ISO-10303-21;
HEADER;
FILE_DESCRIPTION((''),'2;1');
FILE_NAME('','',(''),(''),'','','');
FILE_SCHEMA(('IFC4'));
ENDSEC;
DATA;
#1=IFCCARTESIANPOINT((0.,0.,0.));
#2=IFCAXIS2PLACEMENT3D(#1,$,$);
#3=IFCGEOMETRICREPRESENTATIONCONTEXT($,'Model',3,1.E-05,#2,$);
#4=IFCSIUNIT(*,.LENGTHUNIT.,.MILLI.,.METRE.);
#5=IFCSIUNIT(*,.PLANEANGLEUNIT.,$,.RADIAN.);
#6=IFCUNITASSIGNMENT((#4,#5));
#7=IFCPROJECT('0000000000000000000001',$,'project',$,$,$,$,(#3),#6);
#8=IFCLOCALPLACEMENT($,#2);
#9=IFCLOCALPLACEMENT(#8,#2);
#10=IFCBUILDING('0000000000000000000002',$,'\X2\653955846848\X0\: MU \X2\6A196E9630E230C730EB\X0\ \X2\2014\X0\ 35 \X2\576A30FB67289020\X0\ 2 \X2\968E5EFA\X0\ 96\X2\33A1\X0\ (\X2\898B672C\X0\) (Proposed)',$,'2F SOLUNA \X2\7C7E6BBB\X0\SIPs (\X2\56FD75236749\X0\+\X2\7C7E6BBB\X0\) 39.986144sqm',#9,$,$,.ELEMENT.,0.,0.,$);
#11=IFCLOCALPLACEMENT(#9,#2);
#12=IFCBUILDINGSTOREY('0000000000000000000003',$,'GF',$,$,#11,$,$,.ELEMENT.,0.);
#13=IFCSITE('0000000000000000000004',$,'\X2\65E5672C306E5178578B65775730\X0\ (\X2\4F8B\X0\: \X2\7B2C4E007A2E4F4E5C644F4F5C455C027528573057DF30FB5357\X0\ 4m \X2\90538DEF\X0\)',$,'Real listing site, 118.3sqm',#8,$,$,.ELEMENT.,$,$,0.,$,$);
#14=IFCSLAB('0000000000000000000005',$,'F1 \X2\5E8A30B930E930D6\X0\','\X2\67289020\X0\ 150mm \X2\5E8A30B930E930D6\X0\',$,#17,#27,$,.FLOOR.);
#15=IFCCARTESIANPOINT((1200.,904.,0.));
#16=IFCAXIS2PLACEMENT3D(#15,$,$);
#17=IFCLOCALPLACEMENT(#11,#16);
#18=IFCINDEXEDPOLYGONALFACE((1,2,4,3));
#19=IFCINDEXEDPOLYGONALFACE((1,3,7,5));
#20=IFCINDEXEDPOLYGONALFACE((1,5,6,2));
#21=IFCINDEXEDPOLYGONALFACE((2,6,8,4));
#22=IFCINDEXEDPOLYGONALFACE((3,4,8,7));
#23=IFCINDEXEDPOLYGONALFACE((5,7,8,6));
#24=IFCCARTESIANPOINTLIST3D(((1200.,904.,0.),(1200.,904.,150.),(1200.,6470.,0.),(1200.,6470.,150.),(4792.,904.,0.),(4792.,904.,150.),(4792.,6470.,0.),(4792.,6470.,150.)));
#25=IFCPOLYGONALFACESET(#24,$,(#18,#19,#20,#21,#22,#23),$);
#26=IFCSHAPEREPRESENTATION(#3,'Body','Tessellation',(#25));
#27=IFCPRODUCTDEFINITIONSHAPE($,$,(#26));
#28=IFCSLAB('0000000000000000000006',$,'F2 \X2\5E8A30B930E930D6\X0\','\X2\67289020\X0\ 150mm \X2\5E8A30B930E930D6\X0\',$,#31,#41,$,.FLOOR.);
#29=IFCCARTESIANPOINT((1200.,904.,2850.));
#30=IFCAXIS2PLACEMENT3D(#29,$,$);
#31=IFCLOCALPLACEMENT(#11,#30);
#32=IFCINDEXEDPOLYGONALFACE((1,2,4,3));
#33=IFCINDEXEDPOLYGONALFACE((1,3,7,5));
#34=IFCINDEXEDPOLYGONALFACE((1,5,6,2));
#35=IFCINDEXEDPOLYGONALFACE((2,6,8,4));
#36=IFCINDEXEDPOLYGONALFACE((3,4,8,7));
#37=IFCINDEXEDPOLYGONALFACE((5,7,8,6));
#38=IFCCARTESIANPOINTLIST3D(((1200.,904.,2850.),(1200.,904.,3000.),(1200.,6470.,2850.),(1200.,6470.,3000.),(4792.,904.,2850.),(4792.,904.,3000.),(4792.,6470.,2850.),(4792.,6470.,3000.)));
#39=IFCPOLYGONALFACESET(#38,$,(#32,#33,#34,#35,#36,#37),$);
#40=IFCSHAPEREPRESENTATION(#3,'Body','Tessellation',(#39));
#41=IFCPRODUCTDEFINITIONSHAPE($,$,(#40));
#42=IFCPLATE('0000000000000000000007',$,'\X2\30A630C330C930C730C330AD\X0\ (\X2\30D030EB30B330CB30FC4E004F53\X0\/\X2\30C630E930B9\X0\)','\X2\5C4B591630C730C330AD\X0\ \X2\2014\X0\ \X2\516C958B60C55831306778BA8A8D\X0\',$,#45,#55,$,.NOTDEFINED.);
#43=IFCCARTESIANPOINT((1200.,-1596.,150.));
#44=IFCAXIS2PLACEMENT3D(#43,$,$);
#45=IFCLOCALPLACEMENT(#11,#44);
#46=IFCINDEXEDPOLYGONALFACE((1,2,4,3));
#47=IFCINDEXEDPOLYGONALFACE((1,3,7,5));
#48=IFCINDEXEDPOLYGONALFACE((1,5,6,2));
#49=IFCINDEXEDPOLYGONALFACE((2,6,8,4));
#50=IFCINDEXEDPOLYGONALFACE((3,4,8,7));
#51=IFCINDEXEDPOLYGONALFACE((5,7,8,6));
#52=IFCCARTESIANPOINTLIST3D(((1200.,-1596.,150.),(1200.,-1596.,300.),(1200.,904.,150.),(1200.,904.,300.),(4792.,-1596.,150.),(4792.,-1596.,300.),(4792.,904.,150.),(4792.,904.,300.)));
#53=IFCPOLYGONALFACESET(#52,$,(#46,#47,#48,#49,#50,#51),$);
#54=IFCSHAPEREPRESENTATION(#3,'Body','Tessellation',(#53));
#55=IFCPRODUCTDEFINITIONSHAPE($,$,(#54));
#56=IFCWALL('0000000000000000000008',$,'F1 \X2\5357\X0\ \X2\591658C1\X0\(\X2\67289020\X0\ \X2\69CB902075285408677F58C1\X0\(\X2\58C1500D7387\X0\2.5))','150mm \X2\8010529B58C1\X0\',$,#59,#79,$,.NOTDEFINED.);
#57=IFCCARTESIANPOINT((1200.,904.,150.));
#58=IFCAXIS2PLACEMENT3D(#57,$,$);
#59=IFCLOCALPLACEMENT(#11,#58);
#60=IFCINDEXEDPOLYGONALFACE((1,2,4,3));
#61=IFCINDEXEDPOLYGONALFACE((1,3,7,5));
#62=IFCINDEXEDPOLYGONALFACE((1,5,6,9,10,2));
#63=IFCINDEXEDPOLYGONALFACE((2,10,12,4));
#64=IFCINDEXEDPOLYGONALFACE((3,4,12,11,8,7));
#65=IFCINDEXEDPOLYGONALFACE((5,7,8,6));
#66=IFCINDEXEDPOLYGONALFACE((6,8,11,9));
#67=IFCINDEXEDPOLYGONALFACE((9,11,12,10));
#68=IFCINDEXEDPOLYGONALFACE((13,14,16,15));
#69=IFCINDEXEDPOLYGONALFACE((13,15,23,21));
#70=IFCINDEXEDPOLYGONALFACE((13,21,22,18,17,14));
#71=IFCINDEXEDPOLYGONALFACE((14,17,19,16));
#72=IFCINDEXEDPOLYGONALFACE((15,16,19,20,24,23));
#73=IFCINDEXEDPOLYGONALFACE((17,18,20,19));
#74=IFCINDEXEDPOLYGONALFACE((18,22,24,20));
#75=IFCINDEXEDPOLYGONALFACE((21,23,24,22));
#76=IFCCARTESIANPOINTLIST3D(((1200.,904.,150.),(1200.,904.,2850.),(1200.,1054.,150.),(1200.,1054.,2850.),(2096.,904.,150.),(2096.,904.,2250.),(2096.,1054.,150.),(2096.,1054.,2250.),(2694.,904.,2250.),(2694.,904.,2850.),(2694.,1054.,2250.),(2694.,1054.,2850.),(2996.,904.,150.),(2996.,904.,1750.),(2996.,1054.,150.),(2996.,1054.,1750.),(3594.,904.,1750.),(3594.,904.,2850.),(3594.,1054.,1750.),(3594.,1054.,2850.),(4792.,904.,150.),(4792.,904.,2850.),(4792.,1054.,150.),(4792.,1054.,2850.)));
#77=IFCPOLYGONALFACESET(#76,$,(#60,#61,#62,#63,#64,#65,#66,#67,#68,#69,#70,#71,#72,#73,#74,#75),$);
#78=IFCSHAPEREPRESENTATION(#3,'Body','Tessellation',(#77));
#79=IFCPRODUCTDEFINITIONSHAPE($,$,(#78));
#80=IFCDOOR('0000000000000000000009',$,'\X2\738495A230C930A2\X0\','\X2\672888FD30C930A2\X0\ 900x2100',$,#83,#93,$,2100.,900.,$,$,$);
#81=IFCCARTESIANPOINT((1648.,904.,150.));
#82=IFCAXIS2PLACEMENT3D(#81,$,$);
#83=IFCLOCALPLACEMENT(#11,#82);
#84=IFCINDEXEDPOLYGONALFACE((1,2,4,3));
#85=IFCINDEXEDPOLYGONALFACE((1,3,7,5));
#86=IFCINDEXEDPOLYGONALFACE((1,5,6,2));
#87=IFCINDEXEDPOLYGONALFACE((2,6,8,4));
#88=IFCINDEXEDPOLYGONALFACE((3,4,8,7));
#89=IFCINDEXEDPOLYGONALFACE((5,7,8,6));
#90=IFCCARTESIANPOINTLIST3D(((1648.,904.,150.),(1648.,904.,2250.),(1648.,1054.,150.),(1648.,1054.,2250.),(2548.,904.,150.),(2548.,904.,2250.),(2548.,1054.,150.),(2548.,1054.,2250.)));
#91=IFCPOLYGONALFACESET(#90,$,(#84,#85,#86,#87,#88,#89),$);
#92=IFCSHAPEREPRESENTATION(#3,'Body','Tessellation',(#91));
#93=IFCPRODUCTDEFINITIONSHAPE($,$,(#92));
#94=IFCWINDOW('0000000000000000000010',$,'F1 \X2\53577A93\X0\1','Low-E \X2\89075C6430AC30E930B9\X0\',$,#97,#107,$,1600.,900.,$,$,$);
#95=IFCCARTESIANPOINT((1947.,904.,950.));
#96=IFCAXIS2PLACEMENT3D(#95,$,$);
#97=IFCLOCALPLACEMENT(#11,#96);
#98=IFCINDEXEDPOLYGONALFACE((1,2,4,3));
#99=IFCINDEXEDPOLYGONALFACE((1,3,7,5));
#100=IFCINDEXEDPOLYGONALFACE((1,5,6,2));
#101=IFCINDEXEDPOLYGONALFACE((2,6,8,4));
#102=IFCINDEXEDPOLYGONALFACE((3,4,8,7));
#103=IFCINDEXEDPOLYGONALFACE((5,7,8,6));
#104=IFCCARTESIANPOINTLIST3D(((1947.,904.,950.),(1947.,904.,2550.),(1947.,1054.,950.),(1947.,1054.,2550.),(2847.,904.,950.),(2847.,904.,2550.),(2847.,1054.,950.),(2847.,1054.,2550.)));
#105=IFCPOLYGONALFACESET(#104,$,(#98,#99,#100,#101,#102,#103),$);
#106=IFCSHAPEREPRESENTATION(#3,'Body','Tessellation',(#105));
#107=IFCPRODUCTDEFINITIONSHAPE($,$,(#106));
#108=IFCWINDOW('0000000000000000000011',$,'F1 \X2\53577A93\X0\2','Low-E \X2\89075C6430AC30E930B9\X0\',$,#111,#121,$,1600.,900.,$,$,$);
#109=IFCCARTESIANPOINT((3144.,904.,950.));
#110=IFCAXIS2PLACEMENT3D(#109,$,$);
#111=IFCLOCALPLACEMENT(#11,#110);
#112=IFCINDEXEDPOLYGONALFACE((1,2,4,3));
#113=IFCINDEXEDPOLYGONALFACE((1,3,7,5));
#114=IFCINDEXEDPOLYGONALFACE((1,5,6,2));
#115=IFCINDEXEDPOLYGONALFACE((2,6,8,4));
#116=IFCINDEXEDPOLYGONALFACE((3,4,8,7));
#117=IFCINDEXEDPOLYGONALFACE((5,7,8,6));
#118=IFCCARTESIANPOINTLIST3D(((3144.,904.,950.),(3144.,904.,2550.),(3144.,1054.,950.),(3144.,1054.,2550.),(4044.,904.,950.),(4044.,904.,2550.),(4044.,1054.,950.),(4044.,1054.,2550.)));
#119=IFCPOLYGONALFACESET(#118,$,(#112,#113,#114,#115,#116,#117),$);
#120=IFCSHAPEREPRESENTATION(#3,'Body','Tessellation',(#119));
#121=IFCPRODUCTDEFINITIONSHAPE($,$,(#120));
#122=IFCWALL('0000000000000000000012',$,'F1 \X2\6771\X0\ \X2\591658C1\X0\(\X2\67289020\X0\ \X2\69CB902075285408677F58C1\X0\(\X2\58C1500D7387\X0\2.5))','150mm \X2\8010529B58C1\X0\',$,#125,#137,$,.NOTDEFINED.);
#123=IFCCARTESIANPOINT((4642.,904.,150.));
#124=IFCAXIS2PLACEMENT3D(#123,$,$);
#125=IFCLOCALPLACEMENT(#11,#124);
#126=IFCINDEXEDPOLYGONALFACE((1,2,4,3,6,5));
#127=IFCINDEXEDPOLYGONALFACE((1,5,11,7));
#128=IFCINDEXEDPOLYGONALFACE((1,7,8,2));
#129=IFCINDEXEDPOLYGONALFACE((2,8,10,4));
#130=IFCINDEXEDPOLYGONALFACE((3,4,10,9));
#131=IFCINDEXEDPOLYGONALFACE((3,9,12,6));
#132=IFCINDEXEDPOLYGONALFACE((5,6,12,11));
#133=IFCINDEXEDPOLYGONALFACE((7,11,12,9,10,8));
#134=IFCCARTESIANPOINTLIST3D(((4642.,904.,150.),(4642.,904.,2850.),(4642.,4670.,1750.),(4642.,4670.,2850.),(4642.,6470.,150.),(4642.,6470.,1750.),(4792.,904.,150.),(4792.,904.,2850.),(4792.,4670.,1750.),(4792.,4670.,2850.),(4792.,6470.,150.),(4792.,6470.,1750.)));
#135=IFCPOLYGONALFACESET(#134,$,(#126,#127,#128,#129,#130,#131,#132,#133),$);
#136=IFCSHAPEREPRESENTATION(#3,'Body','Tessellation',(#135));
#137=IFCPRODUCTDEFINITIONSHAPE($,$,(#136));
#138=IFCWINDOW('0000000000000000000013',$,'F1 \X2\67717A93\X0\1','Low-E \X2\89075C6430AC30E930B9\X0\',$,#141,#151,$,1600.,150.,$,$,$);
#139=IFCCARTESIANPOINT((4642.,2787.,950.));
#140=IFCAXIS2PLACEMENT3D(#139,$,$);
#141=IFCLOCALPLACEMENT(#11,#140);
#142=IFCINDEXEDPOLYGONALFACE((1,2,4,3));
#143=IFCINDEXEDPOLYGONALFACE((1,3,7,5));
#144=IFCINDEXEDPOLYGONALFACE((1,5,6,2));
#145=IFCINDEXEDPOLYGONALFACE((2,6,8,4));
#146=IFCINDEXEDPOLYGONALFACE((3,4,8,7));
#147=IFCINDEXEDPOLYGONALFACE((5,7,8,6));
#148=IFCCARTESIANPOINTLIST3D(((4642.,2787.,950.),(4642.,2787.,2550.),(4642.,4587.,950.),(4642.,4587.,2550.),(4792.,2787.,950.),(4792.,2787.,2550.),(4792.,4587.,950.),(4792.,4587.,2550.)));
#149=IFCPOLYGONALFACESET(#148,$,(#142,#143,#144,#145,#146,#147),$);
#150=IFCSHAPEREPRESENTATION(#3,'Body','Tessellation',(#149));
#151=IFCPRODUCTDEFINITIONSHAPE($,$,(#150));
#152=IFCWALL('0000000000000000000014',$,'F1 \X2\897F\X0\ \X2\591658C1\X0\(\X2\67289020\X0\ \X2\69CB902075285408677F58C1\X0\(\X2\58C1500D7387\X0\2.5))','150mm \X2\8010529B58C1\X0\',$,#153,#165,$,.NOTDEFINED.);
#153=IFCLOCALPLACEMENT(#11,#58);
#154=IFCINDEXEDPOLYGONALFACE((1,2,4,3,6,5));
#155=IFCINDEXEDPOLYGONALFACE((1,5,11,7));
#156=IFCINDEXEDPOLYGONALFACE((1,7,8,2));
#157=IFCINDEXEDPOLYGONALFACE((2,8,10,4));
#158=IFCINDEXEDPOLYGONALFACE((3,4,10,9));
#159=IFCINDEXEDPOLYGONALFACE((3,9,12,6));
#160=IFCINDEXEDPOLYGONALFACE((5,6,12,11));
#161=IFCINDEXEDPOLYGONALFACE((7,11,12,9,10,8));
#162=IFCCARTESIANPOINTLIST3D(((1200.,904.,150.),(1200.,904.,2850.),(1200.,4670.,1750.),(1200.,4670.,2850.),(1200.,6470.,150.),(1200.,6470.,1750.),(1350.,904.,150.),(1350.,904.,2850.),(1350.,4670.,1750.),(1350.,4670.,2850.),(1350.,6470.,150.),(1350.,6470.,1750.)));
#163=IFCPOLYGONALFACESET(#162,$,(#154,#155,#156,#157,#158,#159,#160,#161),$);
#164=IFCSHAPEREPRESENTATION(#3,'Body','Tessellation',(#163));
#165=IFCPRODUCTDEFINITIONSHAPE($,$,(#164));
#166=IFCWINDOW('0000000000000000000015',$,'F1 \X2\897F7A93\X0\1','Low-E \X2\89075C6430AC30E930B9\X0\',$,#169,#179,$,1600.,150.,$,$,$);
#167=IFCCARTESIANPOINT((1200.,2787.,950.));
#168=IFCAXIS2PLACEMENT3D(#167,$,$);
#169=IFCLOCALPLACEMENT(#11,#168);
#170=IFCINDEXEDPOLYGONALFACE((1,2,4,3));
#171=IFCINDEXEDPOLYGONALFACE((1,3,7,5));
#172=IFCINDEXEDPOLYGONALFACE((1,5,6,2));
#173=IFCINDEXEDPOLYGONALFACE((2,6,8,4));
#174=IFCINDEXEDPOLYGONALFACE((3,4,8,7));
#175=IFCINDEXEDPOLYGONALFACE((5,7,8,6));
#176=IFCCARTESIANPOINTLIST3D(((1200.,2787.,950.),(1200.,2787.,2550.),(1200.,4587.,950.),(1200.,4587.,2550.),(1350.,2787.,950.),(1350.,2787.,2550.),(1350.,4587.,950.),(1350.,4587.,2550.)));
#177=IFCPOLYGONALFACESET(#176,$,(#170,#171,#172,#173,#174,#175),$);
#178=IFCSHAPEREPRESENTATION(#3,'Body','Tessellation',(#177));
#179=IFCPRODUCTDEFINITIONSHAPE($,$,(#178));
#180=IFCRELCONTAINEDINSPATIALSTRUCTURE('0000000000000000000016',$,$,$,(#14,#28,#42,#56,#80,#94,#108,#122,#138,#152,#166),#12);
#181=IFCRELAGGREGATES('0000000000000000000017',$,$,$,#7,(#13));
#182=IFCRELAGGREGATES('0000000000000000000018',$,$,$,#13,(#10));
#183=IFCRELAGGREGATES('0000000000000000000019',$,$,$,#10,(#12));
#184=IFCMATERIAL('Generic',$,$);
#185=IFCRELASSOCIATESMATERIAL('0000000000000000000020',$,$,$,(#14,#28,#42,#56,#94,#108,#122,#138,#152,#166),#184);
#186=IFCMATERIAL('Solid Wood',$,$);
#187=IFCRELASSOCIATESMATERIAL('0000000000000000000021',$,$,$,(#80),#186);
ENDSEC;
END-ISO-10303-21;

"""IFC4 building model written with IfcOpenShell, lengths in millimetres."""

from ifc_helpers import new_model, si_unit, frame, frame_2d, origin, place, context, project, spatial, rectangle, extrude, material, element, fill, save


model = new_model("IFC4")

# Units and contexts
model_context = context("Model", 3, precision=1e-05, world=origin())
ifc_project = project(units=[si_unit("LENGTHUNIT", "METRE", prefix="MILLI"), si_unit("PLANEANGLEUNIT", "RADIAN")], contexts=[model_context])

# Site, building, storey
site_placement = place(None, origin())
site = spatial("IfcSite", under=ifc_project, at=site_placement, Name="日本の典型敷地 (例: 第一種低層住居専用地域・南 4m 道路)", ObjectType="Real listing site, 118.3sqm", CompositionType="ELEMENT", RefElevation=0.0)
building_placement = place(site_placement, origin())
building = spatial("IfcBuilding", under=site, at=building_placement, Name="改善案: MU 標準モデル — 35 坪・木造 2 階建 96㎡ (見本) (Proposed)", ObjectType="2F SOLUNA 籾殻SIPs (国産杉+籾殻) 39.986144sqm", CompositionType="ELEMENT", ElevationOfRefHeight=0.0, ElevationOfTerrain=0.0)
storey_placement = place(building_placement, origin())
storey = spatial("IfcBuildingStorey", under=building, at=storey_placement, Name="GF", CompositionType="ELEMENT", Elevation=0.0)

# Slabs
ifc_material_1 = material(Name="Generic")
slab_1_placement = place(storey_placement, frame((1200.0, 904.0, 0.0)))
element("IfcSlab", 1, at=slab_1_placement, inside=storey, material=ifc_material_1, Name="F1 床スラブ", Description="木造 150mm 床スラブ", PredefinedType="FLOOR", context=model_context, shape_type="SweptSolid", body=[
    extrude(rectangle(XDim=3592.0, YDim=5566.0, at=frame_2d((1796.0, 2783.0))), frame((1200.0, 904.0, 0.0)), (0.0, 0.0, 1.0), 150.0),
])
slab_2_placement = place(storey_placement, frame((1200.0, 904.0, 2850.0)))
element("IfcSlab", 2, at=slab_2_placement, inside=storey, material=ifc_material_1, Name="F2 床スラブ", Description="木造 150mm 床スラブ", PredefinedType="FLOOR", context=model_context, shape_type="SweptSolid", body=[
    extrude(rectangle(XDim=3592.0, YDim=5566.0, at=frame_2d((1796.0, 2783.0))), frame((1200.0, 904.0, 2850.0)), (0.0, 0.0, 1.0), 150.0),
])

# Plate
plate_placement = place(storey_placement, frame((1200.0, -1596.0, 150.0)))
element("IfcPlate", 3, at=plate_placement, inside=storey, material=ifc_material_1, Name="ウッドデッキ (バルコニー一体/テラス)", Description="屋外デッキ — 公開情報で確認", PredefinedType="NOTDEFINED", context=model_context, shape_type="SweptSolid", body=[
    extrude(rectangle(XDim=3592.0, YDim=2500.0, at=frame_2d((1796.0, 1250.0))), frame((1200.0, -1596.0, 150.0)), (0.0, 0.0, 1.0), 150.0),
])

# Wall, openings, door, windows
wall_1_placement = place(storey_placement, frame((1200.0, 904.0, 150.0)))
wall_1 = element("IfcWall", 4, at=wall_1_placement, inside=storey, material=ifc_material_1, Name="F1 南 外壁(木造 構造用合板壁(壁倍率2.5))", Description="150mm 耐力壁", PredefinedType="NOTDEFINED", context=model_context, shape_type="SweptSolid", body=[
    extrude(rectangle(XDim=3592.0, YDim=150.0, at=frame_2d((1796.0, 75.0))), frame((1200.0, 904.0, 150.0)), (0.0, 0.0, 1.0), 2700.0),
])
opening_1_placement = place(storey_placement, frame((1648.0, 904.0, 150.0)))
opening_1 = element("IfcOpeningElement", 5, at=opening_1_placement, cuts=wall_1, PredefinedType="NOTDEFINED", context=model_context, shape_type="SweptSolid", body=[
    extrude(rectangle(XDim=900.0, YDim=150.0, at=frame_2d((450.0, 75.0))), frame((1648.0, 904.0, 150.0)), (0.0, 0.0, 1.0), 2100.0),
])
opening_2_placement = place(storey_placement, frame((1947.0, 904.0, 950.0)))
opening_2 = element("IfcOpeningElement", 6, at=opening_2_placement, cuts=wall_1, PredefinedType="NOTDEFINED", context=model_context, shape_type="SweptSolid", body=[
    extrude(rectangle(XDim=900.0, YDim=150.0, at=frame_2d((450.0, 75.0))), frame((1947.0, 904.0, 950.0)), (0.0, 0.0, 1.0), 1600.0),
])
opening_3_placement = place(storey_placement, frame((3144.0, 904.0, 950.0)))
opening_3 = element("IfcOpeningElement", 7, at=opening_3_placement, cuts=wall_1, PredefinedType="NOTDEFINED", context=model_context, shape_type="SweptSolid", body=[
    extrude(rectangle(XDim=900.0, YDim=150.0, at=frame_2d((450.0, 75.0))), frame((3144.0, 904.0, 950.0)), (0.0, 0.0, 1.0), 1600.0),
])
ifc_material_2 = material(Name="Solid Wood")
door_placement = place(storey_placement, frame((1648.0, 904.0, 150.0)))
door = element("IfcDoor", 8, at=door_placement, inside=storey, material=ifc_material_2, Name="玄関ドア", Description="木製ドア 900x2100", OverallHeight=2100.0, OverallWidth=900.0, context=model_context, shape_type="SweptSolid", body=[
    extrude(rectangle(XDim=900.0, YDim=150.0, at=frame_2d((450.0, 75.0))), frame((1648.0, 904.0, 150.0)), (0.0, 0.0, 1.0), 2100.0),
])
fill(opening_1, door)
window_1_placement = place(storey_placement, frame((1947.0, 904.0, 950.0)))
window_1 = element("IfcWindow", 9, at=window_1_placement, inside=storey, material=ifc_material_1, Name="F1 南窓1", Description="Low-E 複層ガラス", OverallHeight=1600.0, OverallWidth=900.0, context=model_context, shape_type="SweptSolid", body=[
    extrude(rectangle(XDim=900.0, YDim=150.0, at=frame_2d((450.0, 75.0))), frame((1947.0, 904.0, 950.0)), (0.0, 0.0, 1.0), 1600.0),
])
fill(opening_2, window_1)
window_2_placement = place(storey_placement, frame((3144.0, 904.0, 950.0)))
window_2 = element("IfcWindow", 10, at=window_2_placement, inside=storey, material=ifc_material_1, Name="F1 南窓2", Description="Low-E 複層ガラス", OverallHeight=1600.0, OverallWidth=900.0, context=model_context, shape_type="SweptSolid", body=[
    extrude(rectangle(XDim=900.0, YDim=150.0, at=frame_2d((450.0, 75.0))), frame((3144.0, 904.0, 950.0)), (0.0, 0.0, 1.0), 1600.0),
])
fill(opening_3, window_2)

# Walls, openings, windows
wall_2_placement = place(storey_placement, frame((4642.0, 904.0, 150.0)))
wall_2 = element("IfcWall", 11, at=wall_2_placement, inside=storey, material=ifc_material_1, Name="F1 東 外壁(木造 構造用合板壁(壁倍率2.5))", Description="150mm 耐力壁", PredefinedType="NOTDEFINED", context=model_context, shape_type="SweptSolid", body=[
    extrude(rectangle(XDim=150.0, YDim=5566.0, at=frame_2d((75.0, 2783.0))), frame((4642.0, 904.0, 150.0)), (0.0, 0.0, 1.0), 2700.0),
])
opening_4_placement = place(storey_placement, frame((4642.0, 2787.0, 950.0)))
opening_4 = element("IfcOpeningElement", 12, at=opening_4_placement, cuts=wall_2, PredefinedType="NOTDEFINED", context=model_context, shape_type="SweptSolid", body=[
    extrude(rectangle(XDim=150.0, YDim=1800.0, at=frame_2d((75.0, 900.0))), frame((4642.0, 2787.0, 950.0)), (0.0, 0.0, 1.0), 1600.0),
])
window_3_placement = place(storey_placement, frame((4642.0, 2787.0, 950.0)))
window_3 = element("IfcWindow", 13, at=window_3_placement, inside=storey, material=ifc_material_1, Name="F1 東窓1", Description="Low-E 複層ガラス", OverallHeight=1600.0, OverallWidth=150.0, context=model_context, shape_type="SweptSolid", body=[
    extrude(rectangle(XDim=150.0, YDim=1800.0, at=frame_2d((75.0, 900.0))), frame((4642.0, 2787.0, 950.0)), (0.0, 0.0, 1.0), 1600.0),
])
fill(opening_4, window_3)
wall_3_placement = place(storey_placement, frame((1200.0, 904.0, 150.0)))
wall_3 = element("IfcWall", 14, at=wall_3_placement, inside=storey, material=ifc_material_1, Name="F1 西 外壁(木造 構造用合板壁(壁倍率2.5))", Description="150mm 耐力壁", PredefinedType="NOTDEFINED", context=model_context, shape_type="SweptSolid", body=[
    extrude(rectangle(XDim=150.0, YDim=5566.0, at=frame_2d((75.0, 2783.0))), frame((1200.0, 904.0, 150.0)), (0.0, 0.0, 1.0), 2700.0),
])
opening_5_placement = place(storey_placement, frame((1200.0, 2787.0, 950.0)))
opening_5 = element("IfcOpeningElement", 15, at=opening_5_placement, cuts=wall_3, PredefinedType="NOTDEFINED", context=model_context, shape_type="SweptSolid", body=[
    extrude(rectangle(XDim=150.0, YDim=1800.0, at=frame_2d((75.0, 900.0))), frame((1200.0, 2787.0, 950.0)), (0.0, 0.0, 1.0), 1600.0),
])
window_4_placement = place(storey_placement, frame((1200.0, 2787.0, 950.0)))
window_4 = element("IfcWindow", 16, at=window_4_placement, inside=storey, material=ifc_material_1, Name="F1 西窓1", Description="Low-E 複層ガラス", OverallHeight=1600.0, OverallWidth=150.0, context=model_context, shape_type="SweptSolid", body=[
    extrude(rectangle(XDim=150.0, YDim=1800.0, at=frame_2d((75.0, 900.0))), frame((1200.0, 2787.0, 950.0)), (0.0, 0.0, 1.0), 1600.0),
])
fill(opening_5, window_4)

save(model, "model.ifc")
